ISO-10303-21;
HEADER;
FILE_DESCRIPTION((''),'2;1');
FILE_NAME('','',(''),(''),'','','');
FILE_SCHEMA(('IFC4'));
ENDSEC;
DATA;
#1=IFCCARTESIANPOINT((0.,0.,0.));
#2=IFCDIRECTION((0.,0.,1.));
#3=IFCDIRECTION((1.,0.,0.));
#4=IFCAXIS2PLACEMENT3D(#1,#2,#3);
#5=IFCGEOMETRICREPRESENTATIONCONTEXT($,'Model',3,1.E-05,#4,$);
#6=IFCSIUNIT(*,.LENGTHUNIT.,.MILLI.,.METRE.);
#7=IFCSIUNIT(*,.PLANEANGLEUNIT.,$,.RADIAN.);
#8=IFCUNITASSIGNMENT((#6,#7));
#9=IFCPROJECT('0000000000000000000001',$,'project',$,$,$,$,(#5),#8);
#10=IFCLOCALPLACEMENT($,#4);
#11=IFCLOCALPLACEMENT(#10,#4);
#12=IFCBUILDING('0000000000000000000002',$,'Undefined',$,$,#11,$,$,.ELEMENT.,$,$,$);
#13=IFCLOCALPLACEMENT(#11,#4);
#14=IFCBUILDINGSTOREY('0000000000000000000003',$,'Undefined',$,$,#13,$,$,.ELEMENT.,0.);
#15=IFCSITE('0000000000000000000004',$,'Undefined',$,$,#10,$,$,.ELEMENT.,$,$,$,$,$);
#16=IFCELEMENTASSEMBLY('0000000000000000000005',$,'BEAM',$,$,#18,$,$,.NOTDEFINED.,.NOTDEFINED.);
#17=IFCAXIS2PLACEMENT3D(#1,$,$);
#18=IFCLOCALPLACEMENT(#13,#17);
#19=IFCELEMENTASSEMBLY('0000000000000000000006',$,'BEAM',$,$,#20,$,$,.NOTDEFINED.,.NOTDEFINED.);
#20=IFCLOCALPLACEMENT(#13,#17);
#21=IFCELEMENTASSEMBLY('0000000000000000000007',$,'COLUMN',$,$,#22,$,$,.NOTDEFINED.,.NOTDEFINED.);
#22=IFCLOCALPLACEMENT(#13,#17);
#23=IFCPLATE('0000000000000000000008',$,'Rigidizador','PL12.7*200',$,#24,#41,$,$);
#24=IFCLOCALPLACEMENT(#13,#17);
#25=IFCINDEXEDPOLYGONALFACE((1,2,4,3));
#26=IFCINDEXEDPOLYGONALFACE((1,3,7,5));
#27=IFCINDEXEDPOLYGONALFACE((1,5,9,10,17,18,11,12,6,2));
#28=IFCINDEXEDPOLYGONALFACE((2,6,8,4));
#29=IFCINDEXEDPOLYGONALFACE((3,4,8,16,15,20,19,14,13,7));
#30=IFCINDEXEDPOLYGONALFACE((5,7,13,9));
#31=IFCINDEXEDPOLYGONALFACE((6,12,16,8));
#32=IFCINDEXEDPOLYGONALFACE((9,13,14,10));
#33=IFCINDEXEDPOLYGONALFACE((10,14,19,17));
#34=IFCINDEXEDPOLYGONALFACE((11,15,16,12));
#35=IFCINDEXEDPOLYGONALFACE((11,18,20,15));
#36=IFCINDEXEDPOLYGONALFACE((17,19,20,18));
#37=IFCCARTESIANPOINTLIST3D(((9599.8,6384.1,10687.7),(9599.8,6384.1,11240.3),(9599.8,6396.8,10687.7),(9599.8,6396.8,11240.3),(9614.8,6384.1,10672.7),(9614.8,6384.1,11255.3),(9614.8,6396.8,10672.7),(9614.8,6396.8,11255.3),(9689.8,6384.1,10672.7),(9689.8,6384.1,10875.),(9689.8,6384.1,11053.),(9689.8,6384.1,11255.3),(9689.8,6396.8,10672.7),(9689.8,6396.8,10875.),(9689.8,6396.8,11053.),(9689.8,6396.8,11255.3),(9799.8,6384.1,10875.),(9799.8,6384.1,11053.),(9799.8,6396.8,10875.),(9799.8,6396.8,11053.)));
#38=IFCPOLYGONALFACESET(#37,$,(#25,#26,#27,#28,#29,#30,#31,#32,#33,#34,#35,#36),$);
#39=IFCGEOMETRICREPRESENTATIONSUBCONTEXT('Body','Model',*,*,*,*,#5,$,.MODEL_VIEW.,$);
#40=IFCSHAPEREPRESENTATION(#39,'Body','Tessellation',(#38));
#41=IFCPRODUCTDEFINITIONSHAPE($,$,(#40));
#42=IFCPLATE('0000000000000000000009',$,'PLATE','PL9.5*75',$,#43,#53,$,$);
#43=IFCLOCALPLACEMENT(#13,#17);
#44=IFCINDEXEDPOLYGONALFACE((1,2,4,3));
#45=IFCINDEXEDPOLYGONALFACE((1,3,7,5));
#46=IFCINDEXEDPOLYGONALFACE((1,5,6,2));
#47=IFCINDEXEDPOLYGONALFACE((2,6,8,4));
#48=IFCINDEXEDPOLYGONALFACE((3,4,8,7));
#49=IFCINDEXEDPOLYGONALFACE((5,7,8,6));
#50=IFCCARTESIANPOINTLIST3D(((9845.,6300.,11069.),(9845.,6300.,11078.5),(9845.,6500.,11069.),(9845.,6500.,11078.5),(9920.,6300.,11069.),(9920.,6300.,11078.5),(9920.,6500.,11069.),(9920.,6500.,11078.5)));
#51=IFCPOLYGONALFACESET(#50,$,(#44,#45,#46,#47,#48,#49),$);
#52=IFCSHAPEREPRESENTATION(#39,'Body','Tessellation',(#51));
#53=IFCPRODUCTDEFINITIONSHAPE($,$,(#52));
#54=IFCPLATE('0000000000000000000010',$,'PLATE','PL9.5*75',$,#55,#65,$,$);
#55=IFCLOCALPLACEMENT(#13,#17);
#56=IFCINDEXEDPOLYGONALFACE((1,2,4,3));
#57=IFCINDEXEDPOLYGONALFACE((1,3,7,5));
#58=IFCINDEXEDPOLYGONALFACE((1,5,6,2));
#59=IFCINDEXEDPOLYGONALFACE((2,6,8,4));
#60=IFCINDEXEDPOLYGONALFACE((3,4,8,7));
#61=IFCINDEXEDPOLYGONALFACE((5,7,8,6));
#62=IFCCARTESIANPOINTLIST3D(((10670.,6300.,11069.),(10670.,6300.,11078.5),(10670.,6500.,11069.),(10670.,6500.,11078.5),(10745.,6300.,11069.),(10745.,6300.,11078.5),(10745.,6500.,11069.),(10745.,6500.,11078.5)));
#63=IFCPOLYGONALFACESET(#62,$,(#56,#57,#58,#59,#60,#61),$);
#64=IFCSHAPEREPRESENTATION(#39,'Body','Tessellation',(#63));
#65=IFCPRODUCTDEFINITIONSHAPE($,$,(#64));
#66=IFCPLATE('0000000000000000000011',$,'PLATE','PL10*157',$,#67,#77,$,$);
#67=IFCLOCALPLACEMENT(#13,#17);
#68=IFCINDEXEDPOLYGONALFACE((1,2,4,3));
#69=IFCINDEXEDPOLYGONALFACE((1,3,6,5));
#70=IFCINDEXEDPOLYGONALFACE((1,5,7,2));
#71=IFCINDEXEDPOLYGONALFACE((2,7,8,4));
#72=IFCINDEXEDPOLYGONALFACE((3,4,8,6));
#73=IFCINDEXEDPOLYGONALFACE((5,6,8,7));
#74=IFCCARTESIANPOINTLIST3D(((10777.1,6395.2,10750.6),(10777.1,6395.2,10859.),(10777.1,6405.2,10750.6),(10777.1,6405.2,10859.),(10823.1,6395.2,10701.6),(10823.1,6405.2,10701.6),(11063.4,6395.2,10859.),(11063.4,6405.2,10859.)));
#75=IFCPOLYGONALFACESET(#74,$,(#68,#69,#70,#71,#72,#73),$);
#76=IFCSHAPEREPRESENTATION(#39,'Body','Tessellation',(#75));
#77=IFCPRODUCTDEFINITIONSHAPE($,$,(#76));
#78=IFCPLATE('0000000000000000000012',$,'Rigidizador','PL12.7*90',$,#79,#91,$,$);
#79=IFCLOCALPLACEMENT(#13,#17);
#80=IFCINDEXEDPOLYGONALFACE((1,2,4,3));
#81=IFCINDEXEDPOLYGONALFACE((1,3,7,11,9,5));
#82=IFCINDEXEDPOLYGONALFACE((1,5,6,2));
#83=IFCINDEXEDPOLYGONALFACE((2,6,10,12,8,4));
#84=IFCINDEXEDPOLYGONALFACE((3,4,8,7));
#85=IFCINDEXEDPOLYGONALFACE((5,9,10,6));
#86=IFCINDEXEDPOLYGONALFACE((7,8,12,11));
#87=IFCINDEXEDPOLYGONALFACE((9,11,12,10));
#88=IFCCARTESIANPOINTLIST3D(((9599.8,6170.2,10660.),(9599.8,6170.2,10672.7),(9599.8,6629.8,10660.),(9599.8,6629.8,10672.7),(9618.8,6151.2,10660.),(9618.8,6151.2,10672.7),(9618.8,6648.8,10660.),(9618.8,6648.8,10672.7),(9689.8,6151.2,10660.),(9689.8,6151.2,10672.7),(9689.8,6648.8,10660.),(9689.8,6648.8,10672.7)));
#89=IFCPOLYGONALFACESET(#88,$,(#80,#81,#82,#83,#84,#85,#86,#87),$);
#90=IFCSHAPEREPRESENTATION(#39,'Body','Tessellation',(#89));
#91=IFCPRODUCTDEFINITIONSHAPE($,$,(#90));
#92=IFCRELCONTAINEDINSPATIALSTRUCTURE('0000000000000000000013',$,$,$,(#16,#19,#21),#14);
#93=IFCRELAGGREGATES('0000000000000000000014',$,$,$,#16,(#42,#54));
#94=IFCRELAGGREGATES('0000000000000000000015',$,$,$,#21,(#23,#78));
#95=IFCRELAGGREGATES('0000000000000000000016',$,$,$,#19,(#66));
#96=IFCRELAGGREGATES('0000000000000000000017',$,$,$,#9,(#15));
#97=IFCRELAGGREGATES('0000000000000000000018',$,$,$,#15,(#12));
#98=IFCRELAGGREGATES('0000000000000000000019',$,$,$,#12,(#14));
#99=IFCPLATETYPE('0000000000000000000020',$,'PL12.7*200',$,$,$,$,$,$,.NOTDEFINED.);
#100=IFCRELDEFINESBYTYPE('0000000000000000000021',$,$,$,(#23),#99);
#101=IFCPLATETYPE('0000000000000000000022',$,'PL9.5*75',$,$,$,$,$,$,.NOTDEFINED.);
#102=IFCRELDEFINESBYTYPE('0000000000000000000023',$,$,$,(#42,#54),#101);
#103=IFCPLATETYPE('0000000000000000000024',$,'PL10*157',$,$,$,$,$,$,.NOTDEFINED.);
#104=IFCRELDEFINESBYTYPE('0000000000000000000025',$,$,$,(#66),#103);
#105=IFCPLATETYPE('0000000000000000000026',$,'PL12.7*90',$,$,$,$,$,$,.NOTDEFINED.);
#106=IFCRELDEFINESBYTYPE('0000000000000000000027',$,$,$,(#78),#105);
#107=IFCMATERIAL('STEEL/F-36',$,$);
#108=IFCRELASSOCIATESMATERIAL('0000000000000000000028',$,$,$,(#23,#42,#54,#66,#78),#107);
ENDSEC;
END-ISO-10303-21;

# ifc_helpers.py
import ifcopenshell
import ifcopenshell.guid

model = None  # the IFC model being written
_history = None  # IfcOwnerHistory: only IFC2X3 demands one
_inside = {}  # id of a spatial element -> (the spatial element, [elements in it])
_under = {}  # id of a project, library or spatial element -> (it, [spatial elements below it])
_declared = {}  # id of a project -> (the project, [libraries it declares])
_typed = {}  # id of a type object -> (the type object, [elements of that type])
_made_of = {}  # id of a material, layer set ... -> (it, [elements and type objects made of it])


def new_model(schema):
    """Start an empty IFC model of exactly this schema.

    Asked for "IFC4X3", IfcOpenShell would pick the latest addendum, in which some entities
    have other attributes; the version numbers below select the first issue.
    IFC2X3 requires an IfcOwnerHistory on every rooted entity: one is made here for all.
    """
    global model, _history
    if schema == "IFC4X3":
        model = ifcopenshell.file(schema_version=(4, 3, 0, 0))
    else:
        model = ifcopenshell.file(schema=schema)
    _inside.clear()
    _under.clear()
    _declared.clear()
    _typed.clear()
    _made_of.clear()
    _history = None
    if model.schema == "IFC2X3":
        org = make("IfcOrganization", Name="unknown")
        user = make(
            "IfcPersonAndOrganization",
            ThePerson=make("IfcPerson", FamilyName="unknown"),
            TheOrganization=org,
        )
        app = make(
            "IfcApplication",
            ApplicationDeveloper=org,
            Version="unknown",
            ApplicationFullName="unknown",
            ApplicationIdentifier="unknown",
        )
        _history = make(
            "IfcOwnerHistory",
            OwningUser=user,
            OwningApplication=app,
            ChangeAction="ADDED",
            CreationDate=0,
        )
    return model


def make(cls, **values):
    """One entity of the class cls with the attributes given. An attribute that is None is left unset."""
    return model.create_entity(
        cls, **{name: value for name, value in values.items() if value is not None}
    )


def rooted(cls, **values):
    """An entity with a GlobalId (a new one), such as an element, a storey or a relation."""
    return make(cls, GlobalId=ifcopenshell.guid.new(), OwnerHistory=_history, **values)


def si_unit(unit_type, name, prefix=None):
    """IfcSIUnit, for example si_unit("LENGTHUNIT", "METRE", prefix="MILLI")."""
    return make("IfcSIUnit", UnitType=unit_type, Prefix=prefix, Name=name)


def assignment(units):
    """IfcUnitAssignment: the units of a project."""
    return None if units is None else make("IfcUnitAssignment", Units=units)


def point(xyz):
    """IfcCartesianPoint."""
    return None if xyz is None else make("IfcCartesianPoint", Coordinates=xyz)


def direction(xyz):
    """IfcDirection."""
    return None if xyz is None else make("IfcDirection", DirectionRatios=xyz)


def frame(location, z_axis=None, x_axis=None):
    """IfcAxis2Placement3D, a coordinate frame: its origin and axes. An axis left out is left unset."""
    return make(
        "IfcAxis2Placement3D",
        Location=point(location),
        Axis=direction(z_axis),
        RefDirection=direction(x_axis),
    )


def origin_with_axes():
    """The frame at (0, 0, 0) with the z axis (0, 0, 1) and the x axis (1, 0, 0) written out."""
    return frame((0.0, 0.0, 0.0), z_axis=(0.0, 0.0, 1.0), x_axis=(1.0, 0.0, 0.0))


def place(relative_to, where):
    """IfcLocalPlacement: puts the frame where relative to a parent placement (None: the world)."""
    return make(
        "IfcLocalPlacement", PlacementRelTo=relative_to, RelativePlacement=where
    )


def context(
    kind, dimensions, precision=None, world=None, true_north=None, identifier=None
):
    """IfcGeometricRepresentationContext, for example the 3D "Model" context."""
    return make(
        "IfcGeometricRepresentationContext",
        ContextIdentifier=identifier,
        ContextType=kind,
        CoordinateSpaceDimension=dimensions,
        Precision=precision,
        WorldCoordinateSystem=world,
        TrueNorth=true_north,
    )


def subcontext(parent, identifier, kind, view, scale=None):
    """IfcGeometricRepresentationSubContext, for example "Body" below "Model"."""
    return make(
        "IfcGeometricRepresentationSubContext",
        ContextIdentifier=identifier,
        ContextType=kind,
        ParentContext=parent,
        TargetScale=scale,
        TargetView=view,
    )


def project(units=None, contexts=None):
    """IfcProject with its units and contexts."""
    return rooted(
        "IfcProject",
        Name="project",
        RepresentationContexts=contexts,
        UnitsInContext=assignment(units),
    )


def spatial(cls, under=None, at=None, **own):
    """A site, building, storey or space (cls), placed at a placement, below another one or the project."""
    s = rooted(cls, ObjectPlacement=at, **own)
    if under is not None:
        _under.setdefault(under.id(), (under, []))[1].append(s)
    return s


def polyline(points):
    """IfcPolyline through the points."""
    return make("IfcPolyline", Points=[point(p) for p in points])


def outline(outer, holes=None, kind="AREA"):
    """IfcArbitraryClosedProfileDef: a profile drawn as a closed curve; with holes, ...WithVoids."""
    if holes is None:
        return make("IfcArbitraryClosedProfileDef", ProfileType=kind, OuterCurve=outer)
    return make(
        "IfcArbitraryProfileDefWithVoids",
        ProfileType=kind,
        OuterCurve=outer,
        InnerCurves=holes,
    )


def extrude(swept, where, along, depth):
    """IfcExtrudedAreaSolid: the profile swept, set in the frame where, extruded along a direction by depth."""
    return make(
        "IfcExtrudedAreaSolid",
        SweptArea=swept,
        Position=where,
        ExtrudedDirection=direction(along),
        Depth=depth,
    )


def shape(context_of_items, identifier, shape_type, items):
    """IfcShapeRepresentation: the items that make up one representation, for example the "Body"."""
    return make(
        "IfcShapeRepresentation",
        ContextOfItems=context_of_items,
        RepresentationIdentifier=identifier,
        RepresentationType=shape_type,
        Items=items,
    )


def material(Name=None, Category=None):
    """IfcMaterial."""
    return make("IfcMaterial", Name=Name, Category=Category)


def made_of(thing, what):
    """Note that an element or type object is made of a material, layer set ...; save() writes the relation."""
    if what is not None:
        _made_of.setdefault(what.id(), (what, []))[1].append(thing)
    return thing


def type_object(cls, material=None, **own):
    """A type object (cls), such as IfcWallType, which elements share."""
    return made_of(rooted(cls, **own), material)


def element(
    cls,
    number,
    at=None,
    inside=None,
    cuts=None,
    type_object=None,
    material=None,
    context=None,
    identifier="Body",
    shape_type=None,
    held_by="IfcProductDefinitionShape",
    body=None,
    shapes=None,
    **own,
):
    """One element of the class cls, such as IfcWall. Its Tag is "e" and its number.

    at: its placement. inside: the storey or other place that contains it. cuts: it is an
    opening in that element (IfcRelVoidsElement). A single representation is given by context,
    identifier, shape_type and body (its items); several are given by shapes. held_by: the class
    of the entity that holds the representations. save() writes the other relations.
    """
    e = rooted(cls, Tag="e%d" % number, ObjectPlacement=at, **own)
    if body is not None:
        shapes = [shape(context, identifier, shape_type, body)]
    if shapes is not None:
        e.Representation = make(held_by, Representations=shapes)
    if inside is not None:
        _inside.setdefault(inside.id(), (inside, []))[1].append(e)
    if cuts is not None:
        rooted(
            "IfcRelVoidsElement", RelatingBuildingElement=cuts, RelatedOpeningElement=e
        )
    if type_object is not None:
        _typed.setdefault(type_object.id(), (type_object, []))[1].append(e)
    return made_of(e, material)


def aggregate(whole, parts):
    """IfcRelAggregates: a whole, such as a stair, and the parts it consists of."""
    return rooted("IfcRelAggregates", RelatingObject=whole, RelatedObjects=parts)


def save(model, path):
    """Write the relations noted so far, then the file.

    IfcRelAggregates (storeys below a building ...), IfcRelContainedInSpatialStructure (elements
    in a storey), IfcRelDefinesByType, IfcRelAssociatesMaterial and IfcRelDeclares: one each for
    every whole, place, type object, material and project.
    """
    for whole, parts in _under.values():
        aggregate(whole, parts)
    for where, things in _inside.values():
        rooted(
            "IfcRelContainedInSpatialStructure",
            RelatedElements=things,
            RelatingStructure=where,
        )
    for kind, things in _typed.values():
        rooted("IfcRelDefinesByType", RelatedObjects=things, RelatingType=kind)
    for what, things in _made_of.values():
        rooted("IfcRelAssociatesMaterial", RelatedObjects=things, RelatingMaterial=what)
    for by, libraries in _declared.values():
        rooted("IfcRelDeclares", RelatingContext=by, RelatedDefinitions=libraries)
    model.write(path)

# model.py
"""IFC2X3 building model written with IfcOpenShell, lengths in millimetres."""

from ifc_helpers import new_model, si_unit, frame, origin_with_axes, place, context, subcontext, project, spatial, polyline, outline, extrude, material, type_object, element, aggregate, save


model = new_model("IFC2X3")

# Units and contexts
model_context = context("Model", 3, precision=1e-05, world=origin_with_axes())
body_context = subcontext(model_context, "Body", "Model", "MODEL_VIEW")
ifc_project = project(units=[si_unit("LENGTHUNIT", "METRE", prefix="MILLI"), si_unit("PLANEANGLEUNIT", "RADIAN")], contexts=[model_context])

# Site, building, storey
site_placement = place(None, origin_with_axes())
site = spatial("IfcSite", under=ifc_project, at=site_placement, Name="Undefined", CompositionType="ELEMENT")
building_placement = place(site_placement, origin_with_axes())
building = spatial("IfcBuilding", under=site, at=building_placement, Name="Undefined", CompositionType="ELEMENT")
storey_placement = place(building_placement, origin_with_axes())
storey = spatial("IfcBuildingStorey", under=building, at=storey_placement, Name="Undefined", CompositionType="ELEMENT", Elevation=0.0)

# Element assemblies
ifc_material_1 = material(Name="STEEL/F-36")
assembly_1_placement = place(storey_placement, origin_with_axes())
assembly_1 = element("IfcElementAssembly", 1, at=assembly_1_placement, inside=storey, Name="BEAM", AssemblyPlace="NOTDEFINED", PredefinedType="NOTDEFINED")
assembly_2_placement = place(storey_placement, origin_with_axes())
assembly_2 = element("IfcElementAssembly", 2, at=assembly_2_placement, inside=storey, Name="BEAM", AssemblyPlace="NOTDEFINED", PredefinedType="NOTDEFINED")

# Element assembly, plate
assembly_3_placement = place(storey_placement, origin_with_axes())
assembly_3 = element("IfcElementAssembly", 3, at=assembly_3_placement, inside=storey, Name="COLUMN", AssemblyPlace="NOTDEFINED", PredefinedType="NOTDEFINED")
plate_type_1 = type_object("IfcPlateType", Name="PL12.7*200", PredefinedType="NOTDEFINED")
plate_1_placement = place(assembly_3_placement, frame((9599.8, 6390.4, 10672.7), z_axis=(0.0, 1.0, 0.0), x_axis=(0.0, 0.0, 1.0)))
plate_1 = element("IfcPlate", 4, at=plate_1_placement, type_object=plate_type_1, material=ifc_material_1, Name="Rigidizador", Description="PL12.7*200", context=body_context, shape_type="SweptSolid", body=[
    extrude(outline(polyline([(0.0, 15.0), (15.0, 0.0), (567.6, 0.0), (582.6, 15.0), (582.6, 90.0), (380.3, 90.0), (380.3, 200.0), (202.3, 200.0), (202.3, 90.0), (0.0, 90.0), (0.0, 15.0)])), frame((0.0, 0.0, -6.3), z_axis=(0.0, 0.0, 1.0), x_axis=(1.0, 0.0, 0.0)), (0.0, 0.0, 1.0), 12.7),
])

# Plates
plate_type_2 = type_object("IfcPlateType", Name="PL9.5*75", PredefinedType="NOTDEFINED")
plate_2_placement = place(assembly_1_placement, frame((9920.0, 6300.0, 11073.8), z_axis=(0.0, 0.0, -1.0), x_axis=(-1.0, 0.0, 0.0)))
plate_2 = element("IfcPlate", 5, at=plate_2_placement, type_object=plate_type_2, material=ifc_material_1, Name="PLATE", Description="PL9.5*75", context=body_context, shape_type="SweptSolid", body=[
    extrude(outline(polyline([(0.0, 0.0), (75.0, 0.0), (75.0, 200.0), (0.0, 200.0), (0.0, 0.0)])), frame((0.0, 0.0, -4.8), z_axis=(0.0, 0.0, 1.0), x_axis=(1.0, 0.0, 0.0)), (0.0, 0.0, 1.0), 9.5),
])
plate_3_placement = place(assembly_1_placement, frame((10670.0, 6300.0, 11073.8), z_axis=(0.0, 0.0, 1.0), x_axis=(1.0, 0.0, 0.0)))
plate_3 = element("IfcPlate", 6, at=plate_3_placement, type_object=plate_type_2, material=ifc_material_1, Name="PLATE", Description="PL9.5*75", context=body_context, shape_type="SweptSolid", body=[
    extrude(outline(polyline([(0.0, 0.0), (75.0, 0.0), (75.0, 200.0), (0.0, 200.0), (0.0, 0.0)])), frame((0.0, 0.0, -4.8), z_axis=(0.0, 0.0, 1.0), x_axis=(1.0, 0.0, 0.0)), (0.0, 0.0, 1.0), 9.5),
])
aggregate(assembly_1, [plate_2, plate_3])
plate_type_3 = type_object("IfcPlateType", Name="PL10*157", PredefinedType="NOTDEFINED")
plate_4_placement = place(assembly_2_placement, frame((10777.1, 6400.2, 10859.0), z_axis=(0.0, 1.0, 0.0), x_axis=(1.0, 0.0, 0.0)))
plate_4 = element("IfcPlate", 7, at=plate_4_placement, type_object=plate_type_3, material=ifc_material_1, Name="PLATE", Description="PL10*157", context=body_context, shape_type="SweptSolid", body=[
    extrude(outline(polyline([(0.0, 0.0), (286.4, 0.0), (46.0, 157.4), (0.0, 108.4), (0.0, 0.0)])), frame((0.0, 0.0, -5.0), z_axis=(0.0, 0.0, 1.0), x_axis=(1.0, 0.0, 0.0)), (0.0, 0.0, 1.0), 10.0),
])
plate_type_4 = type_object("IfcPlateType", Name="PL12.7*90", PredefinedType="NOTDEFINED")
plate_5_placement = place(assembly_3_placement, frame((9689.8, 6151.2, 10666.4), z_axis=(0.0, 0.0, -1.0), x_axis=(-1.0, 0.0, 0.0)))
plate_5 = element("IfcPlate", 8, at=plate_5_placement, type_object=plate_type_4, material=ifc_material_1, Name="Rigidizador", Description="PL12.7*90", context=body_context, shape_type="SweptSolid", body=[
    extrude(outline(polyline([(0.0, 0.0), (71.0, 0.0), (90.0, 19.0), (90.0, 478.6), (71.0, 497.6), (0.0, 497.6), (0.0, 0.0)])), frame((0.0, 0.0, -6.3), z_axis=(0.0, 0.0, 1.0), x_axis=(1.0, 0.0, 0.0)), (0.0, 0.0, 1.0), 12.7),
])
aggregate(assembly_3, [plate_1, plate_5])

aggregate(assembly_2, [plate_4])

save(model, "model.ifc")
